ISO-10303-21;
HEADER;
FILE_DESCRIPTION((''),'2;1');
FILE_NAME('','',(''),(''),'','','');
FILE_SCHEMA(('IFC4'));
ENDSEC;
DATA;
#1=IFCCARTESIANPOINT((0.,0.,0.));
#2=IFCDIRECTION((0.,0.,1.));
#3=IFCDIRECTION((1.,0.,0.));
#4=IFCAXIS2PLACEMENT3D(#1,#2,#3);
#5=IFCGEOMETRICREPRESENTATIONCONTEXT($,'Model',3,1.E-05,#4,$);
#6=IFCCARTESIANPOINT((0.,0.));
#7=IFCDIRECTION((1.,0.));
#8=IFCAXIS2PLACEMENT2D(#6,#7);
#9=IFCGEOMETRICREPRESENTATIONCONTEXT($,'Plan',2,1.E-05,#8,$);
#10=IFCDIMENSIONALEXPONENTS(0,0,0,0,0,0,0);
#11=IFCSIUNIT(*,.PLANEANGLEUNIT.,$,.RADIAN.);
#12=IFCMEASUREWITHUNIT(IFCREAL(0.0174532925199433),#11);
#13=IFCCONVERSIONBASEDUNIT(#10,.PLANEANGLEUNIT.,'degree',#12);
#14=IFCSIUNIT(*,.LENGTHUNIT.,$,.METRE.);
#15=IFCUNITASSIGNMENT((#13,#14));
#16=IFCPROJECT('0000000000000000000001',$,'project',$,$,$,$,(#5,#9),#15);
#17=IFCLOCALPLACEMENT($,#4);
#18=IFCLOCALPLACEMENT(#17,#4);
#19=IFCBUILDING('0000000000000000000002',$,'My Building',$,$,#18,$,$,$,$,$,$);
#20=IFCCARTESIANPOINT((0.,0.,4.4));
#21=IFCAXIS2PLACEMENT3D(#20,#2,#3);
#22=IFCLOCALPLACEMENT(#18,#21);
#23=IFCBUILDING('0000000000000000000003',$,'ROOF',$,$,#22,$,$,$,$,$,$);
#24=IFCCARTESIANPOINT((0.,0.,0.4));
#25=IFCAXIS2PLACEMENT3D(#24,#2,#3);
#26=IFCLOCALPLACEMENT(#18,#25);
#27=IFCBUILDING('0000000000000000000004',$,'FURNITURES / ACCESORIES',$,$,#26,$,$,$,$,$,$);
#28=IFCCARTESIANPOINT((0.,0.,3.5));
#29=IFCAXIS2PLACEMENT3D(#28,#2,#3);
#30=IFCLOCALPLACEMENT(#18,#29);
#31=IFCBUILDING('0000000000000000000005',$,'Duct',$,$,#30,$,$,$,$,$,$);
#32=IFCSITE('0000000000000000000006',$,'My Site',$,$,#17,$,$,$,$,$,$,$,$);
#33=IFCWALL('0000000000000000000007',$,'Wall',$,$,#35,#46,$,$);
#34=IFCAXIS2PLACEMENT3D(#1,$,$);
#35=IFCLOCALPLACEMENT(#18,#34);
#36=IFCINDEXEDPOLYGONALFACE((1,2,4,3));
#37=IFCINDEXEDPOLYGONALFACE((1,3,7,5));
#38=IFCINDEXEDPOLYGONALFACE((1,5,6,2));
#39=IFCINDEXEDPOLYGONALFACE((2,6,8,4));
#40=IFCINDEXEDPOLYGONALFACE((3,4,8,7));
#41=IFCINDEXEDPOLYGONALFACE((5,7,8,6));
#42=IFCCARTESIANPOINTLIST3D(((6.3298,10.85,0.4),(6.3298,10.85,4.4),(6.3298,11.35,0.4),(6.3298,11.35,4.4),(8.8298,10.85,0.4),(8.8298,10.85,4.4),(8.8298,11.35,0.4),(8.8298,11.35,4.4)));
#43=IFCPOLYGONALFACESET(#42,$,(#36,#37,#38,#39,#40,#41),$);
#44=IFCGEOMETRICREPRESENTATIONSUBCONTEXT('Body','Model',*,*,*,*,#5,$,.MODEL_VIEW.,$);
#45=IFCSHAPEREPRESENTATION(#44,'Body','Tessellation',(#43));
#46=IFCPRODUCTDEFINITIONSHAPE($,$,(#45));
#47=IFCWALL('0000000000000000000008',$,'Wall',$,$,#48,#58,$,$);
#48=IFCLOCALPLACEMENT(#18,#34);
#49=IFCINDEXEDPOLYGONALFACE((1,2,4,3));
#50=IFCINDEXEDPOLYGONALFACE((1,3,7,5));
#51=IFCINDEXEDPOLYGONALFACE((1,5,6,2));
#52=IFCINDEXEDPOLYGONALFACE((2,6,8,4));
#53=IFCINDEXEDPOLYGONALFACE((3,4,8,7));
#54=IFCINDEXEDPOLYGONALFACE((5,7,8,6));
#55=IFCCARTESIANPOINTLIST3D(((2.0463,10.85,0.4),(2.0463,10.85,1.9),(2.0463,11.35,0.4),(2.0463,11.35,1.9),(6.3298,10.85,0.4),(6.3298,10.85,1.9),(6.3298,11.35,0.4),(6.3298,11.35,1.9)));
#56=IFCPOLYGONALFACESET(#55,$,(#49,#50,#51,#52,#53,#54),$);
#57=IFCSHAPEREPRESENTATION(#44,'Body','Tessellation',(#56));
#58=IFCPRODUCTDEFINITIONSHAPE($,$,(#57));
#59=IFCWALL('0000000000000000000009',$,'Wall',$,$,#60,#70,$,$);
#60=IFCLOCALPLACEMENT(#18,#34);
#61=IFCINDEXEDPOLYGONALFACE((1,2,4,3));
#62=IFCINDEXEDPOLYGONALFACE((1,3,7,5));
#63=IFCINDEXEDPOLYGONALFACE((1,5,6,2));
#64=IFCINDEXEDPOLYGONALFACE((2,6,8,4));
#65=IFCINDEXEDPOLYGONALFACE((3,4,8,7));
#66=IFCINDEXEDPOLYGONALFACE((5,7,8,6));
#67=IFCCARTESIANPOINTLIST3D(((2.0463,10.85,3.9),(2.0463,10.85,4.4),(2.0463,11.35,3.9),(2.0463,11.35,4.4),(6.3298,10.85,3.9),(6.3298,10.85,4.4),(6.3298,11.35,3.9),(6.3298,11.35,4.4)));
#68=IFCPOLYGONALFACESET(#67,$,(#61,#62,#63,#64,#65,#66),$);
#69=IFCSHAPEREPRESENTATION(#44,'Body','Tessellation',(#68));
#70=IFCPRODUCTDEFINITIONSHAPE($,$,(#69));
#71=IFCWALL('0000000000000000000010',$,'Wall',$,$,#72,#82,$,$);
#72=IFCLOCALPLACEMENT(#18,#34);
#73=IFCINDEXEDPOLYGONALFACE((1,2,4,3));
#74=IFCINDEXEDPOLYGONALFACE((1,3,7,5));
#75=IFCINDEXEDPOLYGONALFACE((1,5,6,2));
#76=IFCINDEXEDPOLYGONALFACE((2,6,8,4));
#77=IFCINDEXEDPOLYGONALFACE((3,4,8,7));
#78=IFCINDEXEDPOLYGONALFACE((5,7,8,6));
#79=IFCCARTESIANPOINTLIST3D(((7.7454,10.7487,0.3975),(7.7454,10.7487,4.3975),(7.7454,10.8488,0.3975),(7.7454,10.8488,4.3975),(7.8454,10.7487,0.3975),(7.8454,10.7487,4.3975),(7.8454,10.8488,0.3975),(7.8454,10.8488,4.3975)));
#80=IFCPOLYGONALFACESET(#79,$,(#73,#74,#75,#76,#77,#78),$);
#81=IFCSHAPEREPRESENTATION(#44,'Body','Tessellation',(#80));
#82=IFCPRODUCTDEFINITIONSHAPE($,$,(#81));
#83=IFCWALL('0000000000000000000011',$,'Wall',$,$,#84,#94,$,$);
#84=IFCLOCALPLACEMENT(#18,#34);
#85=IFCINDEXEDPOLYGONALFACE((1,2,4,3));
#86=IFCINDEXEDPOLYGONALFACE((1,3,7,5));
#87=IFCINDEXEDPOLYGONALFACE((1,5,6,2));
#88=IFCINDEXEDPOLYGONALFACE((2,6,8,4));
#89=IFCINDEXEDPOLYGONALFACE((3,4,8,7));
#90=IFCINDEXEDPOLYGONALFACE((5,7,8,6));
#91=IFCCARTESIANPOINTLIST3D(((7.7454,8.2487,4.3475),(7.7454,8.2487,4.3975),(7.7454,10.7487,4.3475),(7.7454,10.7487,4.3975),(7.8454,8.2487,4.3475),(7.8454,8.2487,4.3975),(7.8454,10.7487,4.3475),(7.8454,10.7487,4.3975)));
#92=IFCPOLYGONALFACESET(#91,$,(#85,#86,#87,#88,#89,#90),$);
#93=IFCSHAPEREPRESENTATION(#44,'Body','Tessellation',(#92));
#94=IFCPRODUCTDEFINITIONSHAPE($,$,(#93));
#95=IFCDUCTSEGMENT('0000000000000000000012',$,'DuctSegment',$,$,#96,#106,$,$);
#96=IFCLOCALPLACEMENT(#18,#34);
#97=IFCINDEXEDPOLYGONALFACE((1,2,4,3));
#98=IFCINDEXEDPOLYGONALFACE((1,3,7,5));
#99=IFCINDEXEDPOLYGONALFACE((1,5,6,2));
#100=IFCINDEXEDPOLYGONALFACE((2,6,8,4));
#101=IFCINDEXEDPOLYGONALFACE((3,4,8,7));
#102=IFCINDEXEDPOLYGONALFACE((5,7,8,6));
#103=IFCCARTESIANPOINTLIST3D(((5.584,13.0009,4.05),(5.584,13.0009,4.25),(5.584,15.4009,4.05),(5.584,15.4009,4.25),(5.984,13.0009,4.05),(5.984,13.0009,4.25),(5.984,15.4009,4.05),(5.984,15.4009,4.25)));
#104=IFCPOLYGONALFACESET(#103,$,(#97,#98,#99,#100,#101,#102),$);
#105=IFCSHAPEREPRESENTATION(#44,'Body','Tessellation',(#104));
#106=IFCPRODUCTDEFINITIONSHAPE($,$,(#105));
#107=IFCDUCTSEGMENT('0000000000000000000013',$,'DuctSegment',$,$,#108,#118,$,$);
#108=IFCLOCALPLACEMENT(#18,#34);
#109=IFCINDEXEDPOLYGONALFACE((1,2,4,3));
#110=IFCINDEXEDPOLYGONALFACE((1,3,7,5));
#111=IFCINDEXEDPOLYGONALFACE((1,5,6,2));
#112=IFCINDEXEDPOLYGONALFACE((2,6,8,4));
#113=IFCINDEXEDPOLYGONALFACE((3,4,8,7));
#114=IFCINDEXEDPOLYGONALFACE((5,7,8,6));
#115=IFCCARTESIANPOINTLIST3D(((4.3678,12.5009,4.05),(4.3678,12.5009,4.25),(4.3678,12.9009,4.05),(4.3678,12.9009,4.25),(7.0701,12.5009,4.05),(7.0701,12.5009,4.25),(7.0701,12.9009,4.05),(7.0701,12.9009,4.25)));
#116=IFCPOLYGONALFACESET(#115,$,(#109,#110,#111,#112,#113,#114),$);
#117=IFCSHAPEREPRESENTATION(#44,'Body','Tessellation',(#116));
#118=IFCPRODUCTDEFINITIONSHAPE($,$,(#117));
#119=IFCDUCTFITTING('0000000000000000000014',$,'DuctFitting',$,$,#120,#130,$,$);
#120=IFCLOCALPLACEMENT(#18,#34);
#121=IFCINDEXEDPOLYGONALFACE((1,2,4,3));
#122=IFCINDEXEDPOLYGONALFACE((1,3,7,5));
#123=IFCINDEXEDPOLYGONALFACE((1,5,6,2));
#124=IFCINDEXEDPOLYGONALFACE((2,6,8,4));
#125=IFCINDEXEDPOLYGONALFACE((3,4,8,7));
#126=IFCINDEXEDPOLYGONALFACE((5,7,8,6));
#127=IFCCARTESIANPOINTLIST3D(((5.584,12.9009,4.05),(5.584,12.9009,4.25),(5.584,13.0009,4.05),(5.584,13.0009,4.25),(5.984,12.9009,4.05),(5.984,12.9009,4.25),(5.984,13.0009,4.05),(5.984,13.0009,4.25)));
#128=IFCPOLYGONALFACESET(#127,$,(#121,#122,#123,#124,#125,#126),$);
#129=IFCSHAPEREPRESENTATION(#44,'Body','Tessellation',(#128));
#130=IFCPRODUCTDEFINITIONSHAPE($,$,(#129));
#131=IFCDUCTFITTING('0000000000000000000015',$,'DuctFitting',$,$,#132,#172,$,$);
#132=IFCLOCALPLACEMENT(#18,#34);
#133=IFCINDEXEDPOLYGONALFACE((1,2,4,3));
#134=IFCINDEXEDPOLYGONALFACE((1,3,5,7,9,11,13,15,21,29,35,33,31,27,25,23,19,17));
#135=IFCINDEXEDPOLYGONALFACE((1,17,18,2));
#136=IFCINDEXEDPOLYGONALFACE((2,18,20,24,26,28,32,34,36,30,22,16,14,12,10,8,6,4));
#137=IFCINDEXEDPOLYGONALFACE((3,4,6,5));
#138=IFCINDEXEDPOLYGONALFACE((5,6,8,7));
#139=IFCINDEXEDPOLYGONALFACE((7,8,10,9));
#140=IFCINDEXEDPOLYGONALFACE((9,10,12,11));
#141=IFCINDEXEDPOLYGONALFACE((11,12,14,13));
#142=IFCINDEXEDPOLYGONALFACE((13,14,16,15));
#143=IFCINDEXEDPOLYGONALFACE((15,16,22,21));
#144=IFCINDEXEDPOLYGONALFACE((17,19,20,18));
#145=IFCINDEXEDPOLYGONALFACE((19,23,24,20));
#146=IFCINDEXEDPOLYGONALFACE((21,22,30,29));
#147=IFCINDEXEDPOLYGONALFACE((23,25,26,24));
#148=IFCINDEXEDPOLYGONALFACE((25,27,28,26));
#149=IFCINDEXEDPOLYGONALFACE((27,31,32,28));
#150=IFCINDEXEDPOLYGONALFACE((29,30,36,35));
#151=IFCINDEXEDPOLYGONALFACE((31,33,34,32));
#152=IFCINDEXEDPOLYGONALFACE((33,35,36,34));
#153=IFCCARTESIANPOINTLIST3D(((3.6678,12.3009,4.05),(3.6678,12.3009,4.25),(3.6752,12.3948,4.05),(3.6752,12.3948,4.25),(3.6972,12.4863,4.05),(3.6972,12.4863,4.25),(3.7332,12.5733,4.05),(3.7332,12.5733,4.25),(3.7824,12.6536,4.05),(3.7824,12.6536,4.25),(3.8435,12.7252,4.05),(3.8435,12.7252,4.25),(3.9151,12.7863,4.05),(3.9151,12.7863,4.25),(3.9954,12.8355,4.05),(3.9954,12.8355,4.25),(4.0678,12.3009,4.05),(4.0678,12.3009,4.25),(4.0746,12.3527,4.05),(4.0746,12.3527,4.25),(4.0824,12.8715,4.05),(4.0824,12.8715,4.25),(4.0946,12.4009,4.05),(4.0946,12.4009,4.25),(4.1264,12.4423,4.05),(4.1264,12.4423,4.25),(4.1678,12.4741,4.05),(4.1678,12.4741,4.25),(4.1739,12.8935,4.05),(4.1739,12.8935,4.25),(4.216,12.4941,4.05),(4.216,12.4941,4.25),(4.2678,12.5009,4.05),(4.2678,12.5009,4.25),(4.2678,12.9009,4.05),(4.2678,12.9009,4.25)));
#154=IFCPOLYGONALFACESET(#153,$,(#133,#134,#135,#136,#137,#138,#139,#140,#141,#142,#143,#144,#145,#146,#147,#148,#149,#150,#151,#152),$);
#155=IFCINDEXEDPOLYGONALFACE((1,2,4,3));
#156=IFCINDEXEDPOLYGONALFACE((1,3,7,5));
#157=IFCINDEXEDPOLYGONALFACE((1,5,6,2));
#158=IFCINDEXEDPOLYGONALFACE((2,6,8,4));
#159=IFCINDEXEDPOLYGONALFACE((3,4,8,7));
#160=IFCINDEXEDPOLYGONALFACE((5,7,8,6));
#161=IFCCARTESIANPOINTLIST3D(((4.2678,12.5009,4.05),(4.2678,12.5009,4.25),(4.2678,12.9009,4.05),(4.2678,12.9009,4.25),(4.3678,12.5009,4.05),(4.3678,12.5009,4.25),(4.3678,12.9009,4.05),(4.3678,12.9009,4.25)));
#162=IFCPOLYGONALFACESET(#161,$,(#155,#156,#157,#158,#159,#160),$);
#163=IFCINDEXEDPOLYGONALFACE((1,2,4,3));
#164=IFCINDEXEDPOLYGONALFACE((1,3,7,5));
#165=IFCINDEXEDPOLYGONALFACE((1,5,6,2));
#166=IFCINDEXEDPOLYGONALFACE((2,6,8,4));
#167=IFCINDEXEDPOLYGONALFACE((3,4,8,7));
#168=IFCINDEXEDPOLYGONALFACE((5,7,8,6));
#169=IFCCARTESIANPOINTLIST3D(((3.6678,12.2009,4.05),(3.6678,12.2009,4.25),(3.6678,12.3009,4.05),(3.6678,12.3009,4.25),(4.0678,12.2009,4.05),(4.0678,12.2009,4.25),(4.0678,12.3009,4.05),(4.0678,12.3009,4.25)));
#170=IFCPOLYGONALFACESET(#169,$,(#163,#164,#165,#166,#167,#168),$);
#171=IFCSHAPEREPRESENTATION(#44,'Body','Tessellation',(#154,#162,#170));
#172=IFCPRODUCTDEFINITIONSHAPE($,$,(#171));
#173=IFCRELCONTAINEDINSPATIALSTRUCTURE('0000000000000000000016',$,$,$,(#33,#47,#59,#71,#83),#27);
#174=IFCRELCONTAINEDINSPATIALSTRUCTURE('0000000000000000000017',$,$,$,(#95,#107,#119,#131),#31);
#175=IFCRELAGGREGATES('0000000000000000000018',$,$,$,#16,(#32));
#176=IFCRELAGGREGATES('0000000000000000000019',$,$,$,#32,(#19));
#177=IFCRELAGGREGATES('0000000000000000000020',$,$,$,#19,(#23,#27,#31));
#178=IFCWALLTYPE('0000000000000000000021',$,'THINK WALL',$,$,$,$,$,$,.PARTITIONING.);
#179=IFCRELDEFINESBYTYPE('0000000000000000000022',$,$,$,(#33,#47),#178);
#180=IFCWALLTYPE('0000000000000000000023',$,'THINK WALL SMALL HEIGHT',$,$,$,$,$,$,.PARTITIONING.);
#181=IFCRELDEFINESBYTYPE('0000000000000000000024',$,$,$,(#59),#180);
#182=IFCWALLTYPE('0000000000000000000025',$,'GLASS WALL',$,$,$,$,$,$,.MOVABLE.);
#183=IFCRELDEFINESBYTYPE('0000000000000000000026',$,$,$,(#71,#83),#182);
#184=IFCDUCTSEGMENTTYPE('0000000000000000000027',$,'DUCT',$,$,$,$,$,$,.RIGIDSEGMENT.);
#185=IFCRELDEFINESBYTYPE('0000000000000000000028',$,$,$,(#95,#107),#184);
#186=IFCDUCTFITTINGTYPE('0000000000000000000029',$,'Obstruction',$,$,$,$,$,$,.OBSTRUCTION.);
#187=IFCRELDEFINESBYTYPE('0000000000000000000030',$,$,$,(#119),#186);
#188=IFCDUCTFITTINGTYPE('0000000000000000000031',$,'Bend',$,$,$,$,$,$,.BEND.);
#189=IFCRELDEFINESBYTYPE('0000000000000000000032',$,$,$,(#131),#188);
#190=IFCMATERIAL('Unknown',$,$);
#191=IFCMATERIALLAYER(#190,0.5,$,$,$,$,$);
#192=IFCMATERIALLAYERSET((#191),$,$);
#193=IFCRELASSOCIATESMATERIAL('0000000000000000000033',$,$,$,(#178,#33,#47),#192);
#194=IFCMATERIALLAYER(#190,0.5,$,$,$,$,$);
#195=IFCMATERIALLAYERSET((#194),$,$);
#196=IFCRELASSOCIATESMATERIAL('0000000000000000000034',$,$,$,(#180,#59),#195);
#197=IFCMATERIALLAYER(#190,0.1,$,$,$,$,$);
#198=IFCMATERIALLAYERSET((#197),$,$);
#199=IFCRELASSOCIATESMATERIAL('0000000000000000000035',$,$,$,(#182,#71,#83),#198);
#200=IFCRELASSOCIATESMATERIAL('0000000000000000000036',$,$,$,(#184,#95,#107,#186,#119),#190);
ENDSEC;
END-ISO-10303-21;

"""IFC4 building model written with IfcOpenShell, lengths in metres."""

from ifc_helpers import new_model, entity, si_unit, converted_unit, frame, origin_with_axes, origin_2d_with_axis, place, context, subcontext, project, spatial, line, arc, indexed_curve, rectangle, outline, extrude, source, transform, mapped, material, layer, layer_set, layer_usage, material_profile, profile_set, profile_usage, type_object, type_shapes, element, save


model = new_model("IFC4")

# Units and contexts
model_context = context("Model", 3, precision=1e-05, world=origin_with_axes())
plan_context = context("Plan", 2, precision=1e-05, world=origin_2d_with_axis())
body_context_1 = subcontext(model_context, "Body", "Model", "MODEL_VIEW")
ifc_project = project(units=[converted_unit("PLANEANGLEUNIT", "degree", entity("IfcReal", 0.0174532925199433), si_unit("PLANEANGLEUNIT", "RADIAN"), dimensions=[0, 0, 0, 0, 0, 0, 0]), si_unit("LENGTHUNIT", "METRE")], contexts=[model_context, plan_context])

# Site, building
site_placement = place(None, origin_with_axes())
site = spatial("IfcSite", under=ifc_project, at=site_placement, Name="My Site")
building_1_placement = place(site_placement, origin_with_axes())
building_1 = spatial("IfcBuilding", under=site, at=building_1_placement, Name="My Building")

# Shared definitions
ifc_material = material(Name="Unknown")

# Shared definitions
building_2_placement = place(building_1_placement, frame((0.0, 0.0, 4.4), z_axis=(0.0, 0.0, 1.0), x_axis=(1.0, 0.0, 0.0)))
building_2 = spatial("IfcBuilding", under=building_1, at=building_2_placement, Name="ROOF")

# Shared definitions
building_3_placement = place(building_1_placement, frame((0.0, 0.0, 0.4), z_axis=(0.0, 0.0, 1.0), x_axis=(1.0, 0.0, 0.0)))
building_3 = spatial("IfcBuilding", under=building_1, at=building_3_placement, Name="FURNITURES / ACCESORIES")

# Walls
ifc_layer_1 = layer(ifc_material, 0.5)
ifc_layer_set_1 = layer_set([ifc_layer_1])
ifc_layer_usage_1 = layer_usage(ifc_layer_set_1, "AXIS2", "POSITIVE", 0.0)
wall_type_1 = type_object("IfcWallType", Name="THINK WALL", PredefinedType="PARTITIONING", material=ifc_layer_set_1)
wall_1_placement = place(building_3_placement, frame((8.8298, 11.35, 0.0), z_axis=(0.0, 0.0, 1.0), x_axis=(-1.0, 0.0, 0.0)))
element("IfcWall", 1, at=wall_1_placement, inside=building_3, type_object=wall_type_1, material=ifc_layer_usage_1, Name="Wall", context=body_context_1, shape_type="SweptSolid", body=[
    extrude(outline(indexed_curve([(0.0, 0.0), (0.0, 0.5), (2.5, 0.5), (2.5, 0.0)], segments=[line(1, 2, 3, 4, 1)])), origin_with_axes(), (0.0, 0.0, 1.0), 4.0),
])
ifc_layer_usage_2 = layer_usage(ifc_layer_set_1, "AXIS2", "POSITIVE", 0.0)
wall_2_placement = place(building_3_placement, frame((6.3298, 11.35, 0.0), z_axis=(0.0, 0.0, 1.0), x_axis=(-1.0, 0.0, 0.0)))
element("IfcWall", 2, at=wall_2_placement, inside=building_3, type_object=wall_type_1, material=ifc_layer_usage_2, Name="Wall", context=body_context_1, shape_type="SweptSolid", body=[
    extrude(outline(indexed_curve([(0.0, 0.0), (0.0, 0.5), (4.2835, 0.5), (4.2835, 0.0)], segments=[line(1, 2, 3, 4, 1)])), origin_with_axes(), (0.0, 0.0, 1.0), 1.5),
])
ifc_layer_2 = layer(ifc_material, 0.5)
ifc_layer_set_2 = layer_set([ifc_layer_2])
ifc_layer_usage_3 = layer_usage(ifc_layer_set_2, "AXIS2", "POSITIVE", 0.0)
wall_type_2 = type_object("IfcWallType", Name="THINK WALL SMALL HEIGHT", PredefinedType="PARTITIONING", material=ifc_layer_set_2)
wall_3_placement = place(building_3_placement, frame((6.3298, 11.35, 3.5), z_axis=(0.0, 0.0, 1.0), x_axis=(-1.0, 0.0, 0.0)))
element("IfcWall", 3, at=wall_3_placement, inside=building_3, type_object=wall_type_2, material=ifc_layer_usage_3, Name="Wall", context=body_context_1, shape_type="SweptSolid", body=[
    extrude(outline(indexed_curve([(0.0, 0.0), (0.0, 0.5), (4.2835, 0.5), (4.2835, 0.0)], segments=[line(1, 2, 3, 4, 1)])), origin_with_axes(), (0.0, 0.0, 1.0), 0.5),
])
ifc_layer_3 = layer(ifc_material, 0.1)
ifc_layer_set_3 = layer_set([ifc_layer_3])
ifc_layer_usage_4 = layer_usage(ifc_layer_set_3, "AXIS2", "POSITIVE", 0.0)
wall_type_3 = type_object("IfcWallType", Name="GLASS WALL", PredefinedType="MOVABLE", material=ifc_layer_set_3)
wall_4_placement = place(building_3_placement, frame((7.7454, 10.8488, -0.0025), z_axis=(0.0, 0.0, 1.0), x_axis=(0.0, -1.0, 0.0)))
element("IfcWall", 4, at=wall_4_placement, inside=building_3, type_object=wall_type_3, material=ifc_layer_usage_4, Name="Wall", context=body_context_1, shape_type="SweptSolid", body=[
    extrude(outline(indexed_curve([(0.0, 0.0), (0.0, 0.1), (0.1, 0.1), (0.1, 0.0)], segments=[line(1, 2, 3, 4, 1)])), origin_with_axes(), (0.0, 0.0, 1.0), 4.0),
])
ifc_layer_usage_5 = layer_usage(ifc_layer_set_3, "AXIS2", "POSITIVE", 0.0)
wall_5_placement = place(building_3_placement, frame((7.7454, 10.7487, 3.9475), z_axis=(0.0, 0.0, 1.0), x_axis=(0.0, -1.0, 0.0)))
element("IfcWall", 5, at=wall_5_placement, inside=building_3, type_object=wall_type_3, material=ifc_layer_usage_5, Name="Wall", context=body_context_1, shape_type="SweptSolid", body=[
    extrude(outline(indexed_curve([(0.0, 0.0), (0.0, 0.1), (2.5, 0.1), (2.5, 0.0)], segments=[line(1, 2, 3, 4, 1)])), origin_with_axes(), (0.0, 0.0, 1.0), 0.05),
])

# Shared definitions
building_4_placement = place(building_1_placement, frame((0.0, 0.0, 3.5), z_axis=(0.0, 0.0, 1.0), x_axis=(1.0, 0.0, 0.0)))
building_4 = spatial("IfcBuilding", under=building_1, at=building_4_placement, Name="Duct")

# Duct segments
ifc_material_profile_1 = material_profile(ifc_material, rectangle(XDim=0.4, YDim=0.2))
ifc_profile_set_1 = profile_set([ifc_material_profile_1])
ifc_profile_usage_1 = profile_usage(ifc_profile_set_1, cardinal=5)
duct_segment_type = type_object("IfcDuctSegmentType", Name="DUCT", PredefinedType="RIGIDSEGMENT", material=ifc_profile_set_1)
duct_segment_1_placement = place(building_4_placement, frame((5.784, 15.4009, 0.65), z_axis=(0.0, -1.0, 0.0), x_axis=(1.0, 0.0, 0.0)))
element("IfcDuctSegment", 6, at=duct_segment_1_placement, inside=building_4, type_object=duct_segment_type, material=ifc_profile_usage_1, Name="DuctSegment", context=body_context_1, shape_type="SweptSolid", body=[
    extrude(rectangle(XDim=0.4, YDim=0.2), origin_with_axes(), (0.0, 0.0, 1.0), 2.4),
])
ifc_profile_usage_2 = profile_usage(ifc_profile_set_1, cardinal=5)
duct_segment_2_placement = place(building_4_placement, frame((4.3678, 12.7009, 0.65), z_axis=(1.0, 0.0, 0.0), x_axis=(0.0, 1.0, 0.0)))
element("IfcDuctSegment", 7, at=duct_segment_2_placement, inside=building_4, type_object=duct_segment_type, material=ifc_profile_usage_2, Name="DuctSegment", context=body_context_1, shape_type="SweptSolid", body=[
    extrude(rectangle(XDim=0.4, YDim=0.2), origin_with_axes(), (0.0, 0.0, 1.0), 2.7023),
])

# Duct fittings
ifc_material_profile_2 = material_profile(ifc_material, rectangle(XDim=0.4, YDim=0.2))
ifc_profile_set_2 = profile_set([ifc_material_profile_2])
ifc_profile_usage_3 = profile_usage(ifc_profile_set_2, cardinal=5)
duct_fitting_type_1 = type_object("IfcDuctFittingType", Name="Obstruction", PredefinedType="OBSTRUCTION", material=ifc_profile_set_2)
duct_fitting_1_placement = place(building_4_placement, frame((5.784, 13.0009, 0.65), z_axis=(0.0, -1.0, 0.0), x_axis=(1.0, 0.0, 0.0)))
element("IfcDuctFitting", 8, at=duct_fitting_1_placement, inside=building_4, type_object=duct_fitting_type_1, material=ifc_profile_usage_3, Name="DuctFitting", context=body_context_1, shape_type="SweptSolid", body=[
    extrude(rectangle(XDim=0.4, YDim=0.2), origin_with_axes(), (0.0, 0.0, 1.0), 0.1),
])
duct_fitting_type_2 = type_object("IfcDuctFittingType", Name="Bend", PredefinedType="BEND")
shared_shape_1 = source(origin_with_axes(), body_context_1, "Body", "SweptSolid", [
    extrude(outline(indexed_curve([(-0.2, 0.0), (-0.2586, -0.1414), (-0.4, -0.2), (-0.4, -0.6), (0.0243, -0.4243), (0.2, 0.0)], segments=[arc(1, 2, 3), line(3, 4), arc(4, 5, 6), line(6, 1)])), frame((0.0, -0.1, -0.1), z_axis=(0.0, -1.0, 0.0), x_axis=(1.0, 0.0, 0.0)), (0.0, 0.0, -1.0), 0.2),
    extrude(rectangle(XDim=0.4, YDim=0.2), origin_with_axes(), (0.0, 0.0, -1.0), 0.1),
    extrude(rectangle(XDim=0.4, YDim=0.2), frame((-0.4, 0.0, -0.5), z_axis=(-1.0, 0.0, 0.0), x_axis=(0.0, 0.0, -1.0)), (0.0, 0.0, 1.0), 0.1),
])
type_shapes(duct_fitting_type_2, [shared_shape_1])
duct_fitting_2_placement = place(building_4_placement, frame((4.3678, 12.7009, 0.65), z_axis=(1.0, 0.0, 0.0), x_axis=(0.0, 1.0, 0.0)))
element("IfcDuctFitting", 9, at=duct_fitting_2_placement, inside=building_4, type_object=duct_fitting_type_2, Name="DuctFitting", context=body_context_1, shape_type="MappedRepresentation", body=[
    mapped(shared_shape_1, transform((0.0, 0.0, 0.0), x_axis=(1.0, 0.0, 0.0), y_axis=(0.0, 1.0, 0.0), z_axis=(0.0, 0.0, 1.0), scale=1.0)),
])

save(model, "model.ifc")
